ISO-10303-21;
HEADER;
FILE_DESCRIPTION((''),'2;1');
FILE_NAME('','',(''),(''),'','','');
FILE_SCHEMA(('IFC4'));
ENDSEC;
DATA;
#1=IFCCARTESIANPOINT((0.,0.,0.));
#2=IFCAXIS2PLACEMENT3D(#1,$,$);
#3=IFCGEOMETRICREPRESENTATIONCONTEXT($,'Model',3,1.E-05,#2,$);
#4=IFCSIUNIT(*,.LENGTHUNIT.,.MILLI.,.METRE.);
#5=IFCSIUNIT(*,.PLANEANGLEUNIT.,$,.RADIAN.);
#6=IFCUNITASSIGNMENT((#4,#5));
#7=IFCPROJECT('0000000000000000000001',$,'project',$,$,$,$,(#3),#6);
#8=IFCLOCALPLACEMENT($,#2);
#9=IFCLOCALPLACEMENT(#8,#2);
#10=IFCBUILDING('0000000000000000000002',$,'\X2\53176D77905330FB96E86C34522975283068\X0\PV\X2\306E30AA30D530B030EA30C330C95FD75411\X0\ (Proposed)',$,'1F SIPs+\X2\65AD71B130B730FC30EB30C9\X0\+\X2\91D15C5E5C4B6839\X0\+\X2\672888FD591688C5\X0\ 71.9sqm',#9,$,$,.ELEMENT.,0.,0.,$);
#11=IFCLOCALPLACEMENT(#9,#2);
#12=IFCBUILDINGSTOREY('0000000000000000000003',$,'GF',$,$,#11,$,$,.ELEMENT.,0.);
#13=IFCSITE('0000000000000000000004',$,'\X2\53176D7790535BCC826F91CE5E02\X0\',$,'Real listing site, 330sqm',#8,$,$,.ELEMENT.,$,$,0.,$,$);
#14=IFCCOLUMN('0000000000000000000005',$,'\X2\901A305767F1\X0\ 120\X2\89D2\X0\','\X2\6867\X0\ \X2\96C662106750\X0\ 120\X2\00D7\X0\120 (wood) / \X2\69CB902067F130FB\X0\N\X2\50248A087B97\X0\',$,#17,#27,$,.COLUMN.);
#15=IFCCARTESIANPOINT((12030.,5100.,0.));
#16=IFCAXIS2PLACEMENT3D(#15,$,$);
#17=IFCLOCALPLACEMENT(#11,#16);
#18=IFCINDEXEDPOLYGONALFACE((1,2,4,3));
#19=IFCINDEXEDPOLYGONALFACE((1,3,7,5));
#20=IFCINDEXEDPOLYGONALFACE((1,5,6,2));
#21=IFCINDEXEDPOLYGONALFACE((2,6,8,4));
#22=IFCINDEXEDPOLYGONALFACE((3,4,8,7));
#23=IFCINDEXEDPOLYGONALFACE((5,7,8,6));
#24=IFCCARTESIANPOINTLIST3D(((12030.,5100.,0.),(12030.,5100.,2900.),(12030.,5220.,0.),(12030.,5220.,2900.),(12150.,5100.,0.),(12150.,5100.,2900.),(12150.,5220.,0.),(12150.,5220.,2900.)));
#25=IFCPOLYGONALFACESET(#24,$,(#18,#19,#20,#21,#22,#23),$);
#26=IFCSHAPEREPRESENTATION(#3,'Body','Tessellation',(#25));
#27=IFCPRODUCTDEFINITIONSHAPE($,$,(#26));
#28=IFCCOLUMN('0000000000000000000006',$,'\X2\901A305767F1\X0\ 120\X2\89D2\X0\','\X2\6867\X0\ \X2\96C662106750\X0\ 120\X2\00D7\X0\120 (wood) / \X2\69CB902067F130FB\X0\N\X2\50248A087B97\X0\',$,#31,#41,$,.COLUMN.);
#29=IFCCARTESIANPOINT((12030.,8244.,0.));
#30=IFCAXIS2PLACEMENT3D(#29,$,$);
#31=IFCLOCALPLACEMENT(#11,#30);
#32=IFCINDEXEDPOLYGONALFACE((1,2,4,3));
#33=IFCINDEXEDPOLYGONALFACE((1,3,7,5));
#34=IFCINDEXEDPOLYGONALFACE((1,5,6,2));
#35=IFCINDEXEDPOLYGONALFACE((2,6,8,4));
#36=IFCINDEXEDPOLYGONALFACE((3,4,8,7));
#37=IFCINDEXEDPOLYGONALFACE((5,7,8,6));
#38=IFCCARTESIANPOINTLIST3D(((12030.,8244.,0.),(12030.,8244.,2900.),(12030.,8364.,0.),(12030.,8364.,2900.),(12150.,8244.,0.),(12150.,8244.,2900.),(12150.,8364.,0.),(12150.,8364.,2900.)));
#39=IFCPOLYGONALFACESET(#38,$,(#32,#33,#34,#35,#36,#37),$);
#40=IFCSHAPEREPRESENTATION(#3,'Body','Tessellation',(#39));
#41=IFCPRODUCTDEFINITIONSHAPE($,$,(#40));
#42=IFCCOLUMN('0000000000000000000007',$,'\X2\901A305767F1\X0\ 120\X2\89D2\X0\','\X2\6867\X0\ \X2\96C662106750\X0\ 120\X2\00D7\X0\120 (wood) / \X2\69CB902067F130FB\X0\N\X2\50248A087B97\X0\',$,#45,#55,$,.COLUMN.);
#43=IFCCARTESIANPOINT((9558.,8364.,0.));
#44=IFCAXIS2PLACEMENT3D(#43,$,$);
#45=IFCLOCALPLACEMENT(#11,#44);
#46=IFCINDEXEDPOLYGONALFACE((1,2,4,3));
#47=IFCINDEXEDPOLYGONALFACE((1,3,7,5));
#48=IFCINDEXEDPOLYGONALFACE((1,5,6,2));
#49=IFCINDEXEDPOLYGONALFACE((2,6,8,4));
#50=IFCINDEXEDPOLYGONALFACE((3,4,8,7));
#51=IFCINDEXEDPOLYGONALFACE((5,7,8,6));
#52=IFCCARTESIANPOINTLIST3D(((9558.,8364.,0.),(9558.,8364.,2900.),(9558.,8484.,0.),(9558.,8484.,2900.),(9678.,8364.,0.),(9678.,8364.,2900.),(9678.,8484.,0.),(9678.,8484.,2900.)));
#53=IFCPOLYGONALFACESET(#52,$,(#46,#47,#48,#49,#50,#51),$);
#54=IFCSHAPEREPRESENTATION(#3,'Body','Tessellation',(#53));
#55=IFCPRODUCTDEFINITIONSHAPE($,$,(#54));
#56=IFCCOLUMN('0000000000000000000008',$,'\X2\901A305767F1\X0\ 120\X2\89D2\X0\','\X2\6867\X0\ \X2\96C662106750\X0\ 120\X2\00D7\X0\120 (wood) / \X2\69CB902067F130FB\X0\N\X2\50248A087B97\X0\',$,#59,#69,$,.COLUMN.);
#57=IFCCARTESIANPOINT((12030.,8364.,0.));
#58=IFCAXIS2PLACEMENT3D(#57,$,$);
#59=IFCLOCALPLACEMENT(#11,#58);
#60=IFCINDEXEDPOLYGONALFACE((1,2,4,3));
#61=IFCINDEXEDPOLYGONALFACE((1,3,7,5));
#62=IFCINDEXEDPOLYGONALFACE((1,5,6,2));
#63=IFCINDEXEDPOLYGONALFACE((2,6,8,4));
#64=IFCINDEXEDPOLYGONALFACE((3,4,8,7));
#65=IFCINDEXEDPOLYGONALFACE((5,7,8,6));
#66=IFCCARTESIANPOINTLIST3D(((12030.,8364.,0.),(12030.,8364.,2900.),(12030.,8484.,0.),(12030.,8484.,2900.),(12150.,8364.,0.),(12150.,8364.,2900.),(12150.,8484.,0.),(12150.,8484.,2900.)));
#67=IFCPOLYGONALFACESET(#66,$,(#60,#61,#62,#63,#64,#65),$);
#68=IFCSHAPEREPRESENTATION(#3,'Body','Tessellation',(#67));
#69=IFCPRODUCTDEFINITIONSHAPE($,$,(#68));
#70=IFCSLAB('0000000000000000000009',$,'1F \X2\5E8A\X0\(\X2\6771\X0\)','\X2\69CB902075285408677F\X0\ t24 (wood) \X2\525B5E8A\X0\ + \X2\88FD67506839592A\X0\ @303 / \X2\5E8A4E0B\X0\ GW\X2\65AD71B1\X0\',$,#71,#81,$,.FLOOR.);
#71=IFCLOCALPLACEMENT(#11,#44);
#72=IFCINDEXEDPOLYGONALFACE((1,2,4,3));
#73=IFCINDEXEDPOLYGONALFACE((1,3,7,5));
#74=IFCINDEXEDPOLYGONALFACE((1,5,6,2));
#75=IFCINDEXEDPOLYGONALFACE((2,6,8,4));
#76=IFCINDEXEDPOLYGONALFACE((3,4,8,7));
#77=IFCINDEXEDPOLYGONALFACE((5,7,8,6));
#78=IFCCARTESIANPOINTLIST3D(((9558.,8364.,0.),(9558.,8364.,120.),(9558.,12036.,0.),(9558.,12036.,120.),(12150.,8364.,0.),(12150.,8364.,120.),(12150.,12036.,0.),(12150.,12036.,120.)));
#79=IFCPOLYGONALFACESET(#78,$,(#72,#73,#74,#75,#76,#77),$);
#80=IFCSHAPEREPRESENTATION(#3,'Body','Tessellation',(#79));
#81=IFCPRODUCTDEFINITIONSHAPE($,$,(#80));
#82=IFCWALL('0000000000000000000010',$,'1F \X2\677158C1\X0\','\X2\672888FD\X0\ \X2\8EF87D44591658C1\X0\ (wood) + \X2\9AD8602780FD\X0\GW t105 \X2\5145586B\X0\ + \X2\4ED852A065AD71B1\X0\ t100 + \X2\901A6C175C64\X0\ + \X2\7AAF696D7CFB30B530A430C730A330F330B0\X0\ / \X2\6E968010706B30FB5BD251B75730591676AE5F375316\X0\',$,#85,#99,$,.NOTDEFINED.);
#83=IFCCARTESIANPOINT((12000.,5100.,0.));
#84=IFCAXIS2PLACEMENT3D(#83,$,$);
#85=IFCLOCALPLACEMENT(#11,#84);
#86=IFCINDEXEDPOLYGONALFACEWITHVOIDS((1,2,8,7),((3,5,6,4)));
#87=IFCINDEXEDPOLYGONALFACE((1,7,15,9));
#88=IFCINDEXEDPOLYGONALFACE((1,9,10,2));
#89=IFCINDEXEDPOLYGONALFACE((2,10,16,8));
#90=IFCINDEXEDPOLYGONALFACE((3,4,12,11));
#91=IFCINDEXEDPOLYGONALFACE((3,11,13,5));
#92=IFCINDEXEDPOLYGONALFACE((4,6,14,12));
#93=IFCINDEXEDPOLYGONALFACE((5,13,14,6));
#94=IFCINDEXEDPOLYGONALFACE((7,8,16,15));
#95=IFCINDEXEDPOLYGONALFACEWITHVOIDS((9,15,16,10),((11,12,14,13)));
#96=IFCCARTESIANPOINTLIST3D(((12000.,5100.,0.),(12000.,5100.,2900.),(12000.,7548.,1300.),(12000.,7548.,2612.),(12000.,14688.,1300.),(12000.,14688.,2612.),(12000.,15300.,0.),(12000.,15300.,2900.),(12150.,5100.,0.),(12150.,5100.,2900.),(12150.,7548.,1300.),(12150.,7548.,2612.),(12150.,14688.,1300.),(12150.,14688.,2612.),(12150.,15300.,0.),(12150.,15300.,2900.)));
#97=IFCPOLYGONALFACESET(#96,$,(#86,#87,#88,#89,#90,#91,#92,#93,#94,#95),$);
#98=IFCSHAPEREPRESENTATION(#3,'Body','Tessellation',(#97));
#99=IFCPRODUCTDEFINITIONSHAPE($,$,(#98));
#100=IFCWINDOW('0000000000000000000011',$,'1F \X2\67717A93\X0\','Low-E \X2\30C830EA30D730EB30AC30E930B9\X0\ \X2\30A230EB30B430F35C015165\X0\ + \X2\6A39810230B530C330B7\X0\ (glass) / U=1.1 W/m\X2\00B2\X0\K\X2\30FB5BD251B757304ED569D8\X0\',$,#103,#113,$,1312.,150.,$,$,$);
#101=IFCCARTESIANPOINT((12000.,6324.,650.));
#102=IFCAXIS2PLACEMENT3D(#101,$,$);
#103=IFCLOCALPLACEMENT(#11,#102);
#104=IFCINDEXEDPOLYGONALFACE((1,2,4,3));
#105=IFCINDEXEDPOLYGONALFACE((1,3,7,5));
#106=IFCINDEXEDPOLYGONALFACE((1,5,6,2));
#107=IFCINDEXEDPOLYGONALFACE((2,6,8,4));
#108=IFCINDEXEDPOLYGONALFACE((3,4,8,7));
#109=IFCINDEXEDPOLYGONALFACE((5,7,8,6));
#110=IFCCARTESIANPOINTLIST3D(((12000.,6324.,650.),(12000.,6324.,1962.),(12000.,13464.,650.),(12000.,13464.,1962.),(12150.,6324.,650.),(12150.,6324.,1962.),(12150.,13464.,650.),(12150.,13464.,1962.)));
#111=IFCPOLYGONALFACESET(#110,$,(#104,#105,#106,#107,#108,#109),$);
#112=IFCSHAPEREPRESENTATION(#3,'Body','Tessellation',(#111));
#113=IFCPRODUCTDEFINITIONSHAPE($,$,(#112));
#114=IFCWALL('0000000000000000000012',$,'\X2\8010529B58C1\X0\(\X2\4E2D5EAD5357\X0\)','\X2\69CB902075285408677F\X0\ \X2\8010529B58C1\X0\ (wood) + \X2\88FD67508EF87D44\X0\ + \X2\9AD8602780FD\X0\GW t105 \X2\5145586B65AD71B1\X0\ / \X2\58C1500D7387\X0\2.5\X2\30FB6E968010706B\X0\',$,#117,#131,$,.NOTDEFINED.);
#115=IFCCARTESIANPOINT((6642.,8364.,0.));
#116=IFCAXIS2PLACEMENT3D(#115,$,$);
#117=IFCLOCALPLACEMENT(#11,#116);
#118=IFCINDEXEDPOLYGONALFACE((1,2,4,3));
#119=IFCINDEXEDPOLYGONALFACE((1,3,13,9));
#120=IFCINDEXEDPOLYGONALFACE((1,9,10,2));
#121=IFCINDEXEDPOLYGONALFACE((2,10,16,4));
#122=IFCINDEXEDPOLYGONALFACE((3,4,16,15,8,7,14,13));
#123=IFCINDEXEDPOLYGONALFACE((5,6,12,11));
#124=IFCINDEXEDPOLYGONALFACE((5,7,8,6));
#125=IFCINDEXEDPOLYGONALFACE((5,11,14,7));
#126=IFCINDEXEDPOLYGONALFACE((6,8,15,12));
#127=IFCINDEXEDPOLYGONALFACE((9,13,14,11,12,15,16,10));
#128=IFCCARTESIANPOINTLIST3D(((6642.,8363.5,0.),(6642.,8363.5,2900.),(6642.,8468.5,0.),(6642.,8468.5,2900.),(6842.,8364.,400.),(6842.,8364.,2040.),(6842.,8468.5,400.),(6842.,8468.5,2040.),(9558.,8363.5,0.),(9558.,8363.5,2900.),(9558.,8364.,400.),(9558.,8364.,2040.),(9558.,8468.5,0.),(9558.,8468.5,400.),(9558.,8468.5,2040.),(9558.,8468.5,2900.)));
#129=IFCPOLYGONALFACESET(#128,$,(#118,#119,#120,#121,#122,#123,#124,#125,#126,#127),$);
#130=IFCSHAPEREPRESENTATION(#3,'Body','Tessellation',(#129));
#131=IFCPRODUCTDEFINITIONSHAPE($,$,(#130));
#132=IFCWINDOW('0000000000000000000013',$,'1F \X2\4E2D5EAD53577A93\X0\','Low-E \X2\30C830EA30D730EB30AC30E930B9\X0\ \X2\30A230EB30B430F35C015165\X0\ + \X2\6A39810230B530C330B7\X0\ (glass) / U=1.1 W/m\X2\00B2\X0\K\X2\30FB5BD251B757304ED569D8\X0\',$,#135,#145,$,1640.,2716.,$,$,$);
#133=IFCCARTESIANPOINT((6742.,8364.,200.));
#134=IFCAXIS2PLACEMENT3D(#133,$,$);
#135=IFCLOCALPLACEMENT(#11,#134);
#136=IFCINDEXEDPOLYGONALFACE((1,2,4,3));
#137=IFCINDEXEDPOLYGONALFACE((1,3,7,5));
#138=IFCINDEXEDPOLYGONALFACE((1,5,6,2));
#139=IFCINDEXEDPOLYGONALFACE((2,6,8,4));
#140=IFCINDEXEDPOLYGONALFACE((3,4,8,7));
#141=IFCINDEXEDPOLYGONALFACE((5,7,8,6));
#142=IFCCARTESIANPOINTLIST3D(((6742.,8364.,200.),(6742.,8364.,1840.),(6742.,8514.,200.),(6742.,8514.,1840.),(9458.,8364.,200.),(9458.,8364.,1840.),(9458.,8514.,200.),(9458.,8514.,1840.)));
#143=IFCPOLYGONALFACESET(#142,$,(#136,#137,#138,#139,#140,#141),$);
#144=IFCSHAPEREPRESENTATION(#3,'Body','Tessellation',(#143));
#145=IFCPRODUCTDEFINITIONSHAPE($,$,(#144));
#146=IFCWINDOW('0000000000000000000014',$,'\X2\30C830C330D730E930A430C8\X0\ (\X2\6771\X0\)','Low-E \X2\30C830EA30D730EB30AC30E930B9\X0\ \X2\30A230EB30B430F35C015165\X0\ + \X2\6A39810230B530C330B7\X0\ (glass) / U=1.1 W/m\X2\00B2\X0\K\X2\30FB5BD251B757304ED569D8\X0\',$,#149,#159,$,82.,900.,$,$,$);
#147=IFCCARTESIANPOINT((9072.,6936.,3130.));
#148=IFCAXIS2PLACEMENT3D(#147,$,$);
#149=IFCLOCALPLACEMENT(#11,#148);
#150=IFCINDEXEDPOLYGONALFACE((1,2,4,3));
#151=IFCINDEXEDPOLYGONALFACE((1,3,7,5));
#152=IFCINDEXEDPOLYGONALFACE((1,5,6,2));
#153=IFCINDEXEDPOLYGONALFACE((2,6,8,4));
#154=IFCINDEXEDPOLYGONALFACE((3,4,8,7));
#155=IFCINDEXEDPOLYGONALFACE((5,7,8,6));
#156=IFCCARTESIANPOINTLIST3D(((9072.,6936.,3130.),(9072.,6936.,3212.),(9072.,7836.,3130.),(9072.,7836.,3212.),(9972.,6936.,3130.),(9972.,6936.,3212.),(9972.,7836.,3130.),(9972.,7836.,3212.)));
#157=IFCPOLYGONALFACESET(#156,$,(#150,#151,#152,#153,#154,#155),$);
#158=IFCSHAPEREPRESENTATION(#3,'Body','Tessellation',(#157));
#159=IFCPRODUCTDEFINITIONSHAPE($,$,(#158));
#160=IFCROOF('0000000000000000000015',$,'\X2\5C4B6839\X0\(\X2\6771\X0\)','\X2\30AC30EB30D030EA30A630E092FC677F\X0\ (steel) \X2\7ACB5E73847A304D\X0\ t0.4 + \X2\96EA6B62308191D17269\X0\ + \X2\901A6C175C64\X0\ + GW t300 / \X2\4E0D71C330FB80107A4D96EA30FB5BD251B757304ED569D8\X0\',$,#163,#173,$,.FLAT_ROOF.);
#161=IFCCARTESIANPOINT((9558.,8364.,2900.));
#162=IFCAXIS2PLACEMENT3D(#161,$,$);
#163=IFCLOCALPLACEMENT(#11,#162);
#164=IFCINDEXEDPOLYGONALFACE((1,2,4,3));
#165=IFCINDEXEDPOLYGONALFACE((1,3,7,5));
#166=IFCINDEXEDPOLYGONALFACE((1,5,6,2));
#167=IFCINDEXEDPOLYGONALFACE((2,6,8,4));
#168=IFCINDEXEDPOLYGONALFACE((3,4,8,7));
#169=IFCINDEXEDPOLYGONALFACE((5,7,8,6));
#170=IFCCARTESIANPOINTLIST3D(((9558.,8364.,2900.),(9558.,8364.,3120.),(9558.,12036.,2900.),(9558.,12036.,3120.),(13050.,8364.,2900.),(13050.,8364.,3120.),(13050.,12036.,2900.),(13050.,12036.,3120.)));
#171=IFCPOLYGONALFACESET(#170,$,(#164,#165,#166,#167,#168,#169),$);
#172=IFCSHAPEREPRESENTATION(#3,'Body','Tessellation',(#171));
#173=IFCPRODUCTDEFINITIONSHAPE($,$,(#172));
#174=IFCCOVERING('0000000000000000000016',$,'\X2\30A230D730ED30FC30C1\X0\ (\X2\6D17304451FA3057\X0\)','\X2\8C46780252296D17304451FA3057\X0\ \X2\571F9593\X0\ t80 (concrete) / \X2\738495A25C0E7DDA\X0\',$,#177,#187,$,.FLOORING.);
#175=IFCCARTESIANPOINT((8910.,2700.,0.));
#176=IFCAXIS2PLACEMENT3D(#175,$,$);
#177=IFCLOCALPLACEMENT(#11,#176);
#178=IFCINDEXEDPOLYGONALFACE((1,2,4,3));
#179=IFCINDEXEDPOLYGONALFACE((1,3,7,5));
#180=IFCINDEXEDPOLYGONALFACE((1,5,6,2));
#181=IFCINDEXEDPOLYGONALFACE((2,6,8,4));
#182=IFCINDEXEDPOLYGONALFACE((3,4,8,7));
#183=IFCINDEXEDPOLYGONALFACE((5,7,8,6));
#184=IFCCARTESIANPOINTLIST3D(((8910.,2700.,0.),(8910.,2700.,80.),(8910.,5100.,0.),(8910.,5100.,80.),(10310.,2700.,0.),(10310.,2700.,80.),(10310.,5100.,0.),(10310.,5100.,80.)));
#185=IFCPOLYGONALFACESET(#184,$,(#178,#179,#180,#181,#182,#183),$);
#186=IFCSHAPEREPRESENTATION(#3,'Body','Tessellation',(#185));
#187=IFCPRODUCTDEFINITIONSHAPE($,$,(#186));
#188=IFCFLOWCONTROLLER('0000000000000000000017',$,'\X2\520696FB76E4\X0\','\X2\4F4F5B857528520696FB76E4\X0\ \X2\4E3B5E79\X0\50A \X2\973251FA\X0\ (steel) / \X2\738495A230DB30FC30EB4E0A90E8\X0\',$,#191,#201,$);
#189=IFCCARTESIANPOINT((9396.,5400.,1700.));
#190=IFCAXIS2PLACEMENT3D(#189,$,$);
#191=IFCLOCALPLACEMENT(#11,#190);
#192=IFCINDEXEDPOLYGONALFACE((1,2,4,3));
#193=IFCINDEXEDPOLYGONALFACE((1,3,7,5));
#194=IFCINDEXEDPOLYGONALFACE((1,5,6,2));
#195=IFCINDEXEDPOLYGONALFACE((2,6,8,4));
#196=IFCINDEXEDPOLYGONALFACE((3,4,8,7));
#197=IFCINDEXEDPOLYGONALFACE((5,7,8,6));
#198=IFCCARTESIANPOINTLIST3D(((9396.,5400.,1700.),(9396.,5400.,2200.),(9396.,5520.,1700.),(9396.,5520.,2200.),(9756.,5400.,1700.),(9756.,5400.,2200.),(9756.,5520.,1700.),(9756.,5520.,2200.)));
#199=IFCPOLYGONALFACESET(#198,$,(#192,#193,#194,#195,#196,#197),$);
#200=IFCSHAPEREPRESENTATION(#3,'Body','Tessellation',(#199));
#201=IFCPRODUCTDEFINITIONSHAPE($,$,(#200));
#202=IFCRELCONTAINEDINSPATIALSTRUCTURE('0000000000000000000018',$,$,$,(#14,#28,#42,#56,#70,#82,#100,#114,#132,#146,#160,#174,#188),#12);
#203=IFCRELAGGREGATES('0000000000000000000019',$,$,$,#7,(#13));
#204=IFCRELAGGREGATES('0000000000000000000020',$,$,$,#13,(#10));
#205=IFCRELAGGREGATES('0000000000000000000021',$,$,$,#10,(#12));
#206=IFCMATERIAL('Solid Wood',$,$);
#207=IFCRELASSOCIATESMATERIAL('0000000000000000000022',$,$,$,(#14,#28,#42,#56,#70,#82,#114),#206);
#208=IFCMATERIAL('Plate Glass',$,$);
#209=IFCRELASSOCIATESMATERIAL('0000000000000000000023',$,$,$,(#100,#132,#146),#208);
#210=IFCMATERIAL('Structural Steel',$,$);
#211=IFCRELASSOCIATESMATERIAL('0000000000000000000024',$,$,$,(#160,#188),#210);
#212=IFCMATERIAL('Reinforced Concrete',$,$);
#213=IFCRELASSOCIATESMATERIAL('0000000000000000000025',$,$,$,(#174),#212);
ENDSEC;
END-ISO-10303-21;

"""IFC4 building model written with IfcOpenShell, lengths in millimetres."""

from ifc_helpers import new_model, si_unit, frame, frame_2d, origin, place, context, project, spatial, rectangle, extrude, material, element, fill, save


model = new_model("IFC4")

# Units and contexts
model_context = context("Model", 3, precision=1e-05, world=origin())
ifc_project = project(units=[si_unit("LENGTHUNIT", "METRE", prefix="MILLI"), si_unit("PLANEANGLEUNIT", "RADIAN")], contexts=[model_context])

# Site, building, storey
site_placement = place(None, origin())
site = spatial("IfcSite", under=ifc_project, at=site_placement, Name="北海道富良野市", ObjectType="Real listing site, 330sqm", CompositionType="ELEMENT", RefElevation=0.0)
building_placement = place(site_placement, origin())
building = spatial("IfcBuilding", under=site, at=building_placement, Name="北海道・雨水利用とPVのオフグリッド志向 (Proposed)", ObjectType="1F SIPs+断熱シールド+金属屋根+木製外装 71.9sqm", CompositionType="ELEMENT", ElevationOfRefHeight=0.0, ElevationOfTerrain=0.0)
storey_placement = place(building_placement, origin())
storey = spatial("IfcBuildingStorey", under=building, at=storey_placement, Name="GF", CompositionType="ELEMENT", Elevation=0.0)

# Columns
ifc_material_1 = material(Name="Solid Wood")
column_1_placement = place(storey_placement, frame((12030.0, 5100.0, 0.0)))
element("IfcColumn", 1, at=column_1_placement, inside=storey, material=ifc_material_1, Name="通し柱 120角", Description="桧 集成材 120×120 (wood) / 構造柱・N値計算", PredefinedType="COLUMN", context=model_context, shape_type="SweptSolid", body=[
    extrude(rectangle(XDim=120.0, YDim=120.0, at=frame_2d((60.0, 60.0))), frame((12030.0, 5100.0, 0.0)), (0.0, 0.0, 1.0), 2900.0),
])
column_2_placement = place(storey_placement, frame((12030.0, 8244.0, 0.0)))
element("IfcColumn", 2, at=column_2_placement, inside=storey, material=ifc_material_1, Name="通し柱 120角", Description="桧 集成材 120×120 (wood) / 構造柱・N値計算", PredefinedType="COLUMN", context=model_context, shape_type="SweptSolid", body=[
    extrude(rectangle(XDim=120.0, YDim=120.0, at=frame_2d((60.0, 60.0))), frame((12030.0, 8244.0, 0.0)), (0.0, 0.0, 1.0), 2900.0),
])
column_3_placement = place(storey_placement, frame((9558.0, 8364.0, 0.0)))
element("IfcColumn", 3, at=column_3_placement, inside=storey, material=ifc_material_1, Name="通し柱 120角", Description="桧 集成材 120×120 (wood) / 構造柱・N値計算", PredefinedType="COLUMN", context=model_context, shape_type="SweptSolid", body=[
    extrude(rectangle(XDim=120.0, YDim=120.0, at=frame_2d((60.0, 60.0))), frame((9558.0, 8364.0, 0.0)), (0.0, 0.0, 1.0), 2900.0),
])
column_4_placement = place(storey_placement, frame((12030.0, 8364.0, 0.0)))
element("IfcColumn", 4, at=column_4_placement, inside=storey, material=ifc_material_1, Name="通し柱 120角", Description="桧 集成材 120×120 (wood) / 構造柱・N値計算", PredefinedType="COLUMN", context=model_context, shape_type="SweptSolid", body=[
    extrude(rectangle(XDim=120.0, YDim=120.0, at=frame_2d((60.0, 60.0))), frame((12030.0, 8364.0, 0.0)), (0.0, 0.0, 1.0), 2900.0),
])

# Slab
slab_placement = place(storey_placement, frame((9558.0, 8364.0, 0.0)))
element("IfcSlab", 5, at=slab_placement, inside=storey, material=ifc_material_1, Name="1F 床(東)", Description="構造用合板 t24 (wood) 剛床 + 製材根太 @303 / 床下 GW断熱", PredefinedType="FLOOR", context=model_context, shape_type="SweptSolid", body=[
    extrude(rectangle(XDim=2592.0, YDim=3672.0, at=frame_2d((1296.0, 1836.0))), frame((9558.0, 8364.0, 0.0)), (0.0, 0.0, 1.0), 120.0),
])

# Walls, openings, windows
wall_1_placement = place(storey_placement, frame((12000.0, 5100.0, 0.0)))
wall_1 = element("IfcWall", 6, at=wall_1_placement, inside=storey, material=ifc_material_1, Name="1F 東壁", Description="木製 軸組外壁 (wood) + 高性能GW t105 充填 + 付加断熱 t100 + 通気層 + 窯業系サイディング / 準耐火・寒冷地外皮強化", PredefinedType="NOTDEFINED", context=model_context, shape_type="SweptSolid", body=[
    extrude(rectangle(XDim=150.0, YDim=10200.0, at=frame_2d((75.0, 5100.0))), frame((12000.0, 5100.0, 0.0)), (0.0, 0.0, 1.0), 2900.0),
])
opening_1_placement = place(storey_placement, frame((12000.0, 6324.0, 650.0)))
opening_1 = element("IfcOpeningElement", 7, at=opening_1_placement, cuts=wall_1, PredefinedType="NOTDEFINED", context=model_context, shape_type="SweptSolid", body=[
    extrude(rectangle(XDim=150.0, YDim=7140.0, at=frame_2d((75.0, 3570.0))), frame((12000.0, 6324.0, 650.0)), (0.0, 0.0, 1.0), 1312.0),
])
ifc_material_2 = material(Name="Plate Glass")
window_1_placement = place(storey_placement, frame((12000.0, 6324.0, 650.0)))
window_1 = element("IfcWindow", 8, at=window_1_placement, inside=storey, material=ifc_material_2, Name="1F 東窓", Description="Low-E トリプルガラス アルゴン封入 + 樹脂サッシ (glass) / U=1.1 W/m²K・寒冷地仕様", OverallHeight=1312.0, OverallWidth=150.0, context=model_context, shape_type="SweptSolid", body=[
    extrude(rectangle(XDim=150.0, YDim=7140.0, at=frame_2d((75.0, 3570.0))), frame((12000.0, 6324.0, 650.0)), (0.0, 0.0, 1.0), 1312.0),
])
fill(opening_1, window_1)
wall_2_placement = place(storey_placement, frame((6642.0, 8364.0, 0.0)))
wall_2 = element("IfcWall", 9, at=wall_2_placement, inside=storey, material=ifc_material_1, Name="耐力壁(中庭南)", Description="構造用合板 耐力壁 (wood) + 製材軸組 + 高性能GW t105 充填断熱 / 壁倍率2.5・準耐火", PredefinedType="NOTDEFINED", context=model_context, shape_type="SweptSolid", body=[
    extrude(rectangle(XDim=2916.0, YDim=105.0, at=frame_2d((1458.0, 52.0))), frame((6642.0, 8364.0, 0.0)), (0.0, 0.0, 1.0), 2900.0),
])
opening_2_placement = place(storey_placement, frame((6742.0, 8364.0, 200.0)))
opening_2 = element("IfcOpeningElement", 10, at=opening_2_placement, cuts=wall_2, PredefinedType="NOTDEFINED", context=model_context, shape_type="SweptSolid", body=[
    extrude(rectangle(XDim=2716.0, YDim=150.0, at=frame_2d((1358.0, 75.0))), frame((6742.0, 8364.0, 200.0)), (0.0, 0.0, 1.0), 1640.0),
])
window_2_placement = place(storey_placement, frame((6742.0, 8364.0, 200.0)))
window_2 = element("IfcWindow", 11, at=window_2_placement, inside=storey, material=ifc_material_2, Name="1F 中庭南窓", Description="Low-E トリプルガラス アルゴン封入 + 樹脂サッシ (glass) / U=1.1 W/m²K・寒冷地仕様", OverallHeight=1640.0, OverallWidth=2716.0, context=model_context, shape_type="SweptSolid", body=[
    extrude(rectangle(XDim=2716.0, YDim=150.0, at=frame_2d((1358.0, 75.0))), frame((6742.0, 8364.0, 200.0)), (0.0, 0.0, 1.0), 1640.0),
])
fill(opening_2, window_2)

# Window
window_3_placement = place(storey_placement, frame((9072.0, 6936.0, 3130.0)))
element("IfcWindow", 12, at=window_3_placement, inside=storey, material=ifc_material_2, Name="トップライト (東)", Description="Low-E トリプルガラス アルゴン封入 + 樹脂サッシ (glass) / U=1.1 W/m²K・寒冷地仕様", OverallHeight=82.0, OverallWidth=900.0, context=model_context, shape_type="SweptSolid", body=[
    extrude(rectangle(XDim=900.0, YDim=900.0, at=frame_2d((450.0, 450.0))), frame((9072.0, 6936.0, 3130.0)), (0.0, 0.0, 1.0), 82.0),
])

# Roof
ifc_material_3 = material(Name="Structural Steel")
roof_placement = place(storey_placement, frame((9558.0, 8364.0, 2900.0)))
element("IfcRoof", 13, at=roof_placement, inside=storey, material=ifc_material_3, Name="屋根(東)", Description="ガルバリウム鋼板 (steel) 立平葺き t0.4 + 雪止め金物 + 通気層 + GW t300 / 不燃・耐積雪・寒冷地仕様", PredefinedType="FLAT_ROOF", context=model_context, shape_type="SweptSolid", body=[
    extrude(rectangle(XDim=3492.0, YDim=3672.0, at=frame_2d((1746.0, 1836.0))), frame((9558.0, 8364.0, 2900.0)), (0.0, 0.0, 1.0), 220.0),
])

# Covering
ifc_material_4 = material(Name="Reinforced Concrete")
covering_placement = place(storey_placement, frame((8910.0, 2700.0, 0.0)))
element("IfcCovering", 14, at=covering_placement, inside=storey, material=ifc_material_4, Name="アプローチ (洗い出し)", Description="豆砂利洗い出し 土間 t80 (concrete) / 玄関導線", PredefinedType="FLOORING", context=model_context, shape_type="SweptSolid", body=[
    extrude(rectangle(XDim=1400.0, YDim=2400.0, at=frame_2d((700.0, 1200.0))), frame((8910.0, 2700.0, 0.0)), (0.0, 0.0, 1.0), 80.0),
])

# Flow controller
flow_controller_placement = place(storey_placement, frame((9396.0, 5400.0, 1700.0)))
element("IfcFlowController", 15, at=flow_controller_placement, inside=storey, material=ifc_material_3, Name="分電盤", Description="住宅用分電盤 主幹50A 露出 (steel) / 玄関ホール上部", context=model_context, shape_type="SweptSolid", body=[
    extrude(rectangle(XDim=360.0, YDim=120.0, at=frame_2d((180.0, 60.0))), frame((9396.0, 5400.0, 1700.0)), (0.0, 0.0, 1.0), 500.0),
])

save(model, "model.ifc")
